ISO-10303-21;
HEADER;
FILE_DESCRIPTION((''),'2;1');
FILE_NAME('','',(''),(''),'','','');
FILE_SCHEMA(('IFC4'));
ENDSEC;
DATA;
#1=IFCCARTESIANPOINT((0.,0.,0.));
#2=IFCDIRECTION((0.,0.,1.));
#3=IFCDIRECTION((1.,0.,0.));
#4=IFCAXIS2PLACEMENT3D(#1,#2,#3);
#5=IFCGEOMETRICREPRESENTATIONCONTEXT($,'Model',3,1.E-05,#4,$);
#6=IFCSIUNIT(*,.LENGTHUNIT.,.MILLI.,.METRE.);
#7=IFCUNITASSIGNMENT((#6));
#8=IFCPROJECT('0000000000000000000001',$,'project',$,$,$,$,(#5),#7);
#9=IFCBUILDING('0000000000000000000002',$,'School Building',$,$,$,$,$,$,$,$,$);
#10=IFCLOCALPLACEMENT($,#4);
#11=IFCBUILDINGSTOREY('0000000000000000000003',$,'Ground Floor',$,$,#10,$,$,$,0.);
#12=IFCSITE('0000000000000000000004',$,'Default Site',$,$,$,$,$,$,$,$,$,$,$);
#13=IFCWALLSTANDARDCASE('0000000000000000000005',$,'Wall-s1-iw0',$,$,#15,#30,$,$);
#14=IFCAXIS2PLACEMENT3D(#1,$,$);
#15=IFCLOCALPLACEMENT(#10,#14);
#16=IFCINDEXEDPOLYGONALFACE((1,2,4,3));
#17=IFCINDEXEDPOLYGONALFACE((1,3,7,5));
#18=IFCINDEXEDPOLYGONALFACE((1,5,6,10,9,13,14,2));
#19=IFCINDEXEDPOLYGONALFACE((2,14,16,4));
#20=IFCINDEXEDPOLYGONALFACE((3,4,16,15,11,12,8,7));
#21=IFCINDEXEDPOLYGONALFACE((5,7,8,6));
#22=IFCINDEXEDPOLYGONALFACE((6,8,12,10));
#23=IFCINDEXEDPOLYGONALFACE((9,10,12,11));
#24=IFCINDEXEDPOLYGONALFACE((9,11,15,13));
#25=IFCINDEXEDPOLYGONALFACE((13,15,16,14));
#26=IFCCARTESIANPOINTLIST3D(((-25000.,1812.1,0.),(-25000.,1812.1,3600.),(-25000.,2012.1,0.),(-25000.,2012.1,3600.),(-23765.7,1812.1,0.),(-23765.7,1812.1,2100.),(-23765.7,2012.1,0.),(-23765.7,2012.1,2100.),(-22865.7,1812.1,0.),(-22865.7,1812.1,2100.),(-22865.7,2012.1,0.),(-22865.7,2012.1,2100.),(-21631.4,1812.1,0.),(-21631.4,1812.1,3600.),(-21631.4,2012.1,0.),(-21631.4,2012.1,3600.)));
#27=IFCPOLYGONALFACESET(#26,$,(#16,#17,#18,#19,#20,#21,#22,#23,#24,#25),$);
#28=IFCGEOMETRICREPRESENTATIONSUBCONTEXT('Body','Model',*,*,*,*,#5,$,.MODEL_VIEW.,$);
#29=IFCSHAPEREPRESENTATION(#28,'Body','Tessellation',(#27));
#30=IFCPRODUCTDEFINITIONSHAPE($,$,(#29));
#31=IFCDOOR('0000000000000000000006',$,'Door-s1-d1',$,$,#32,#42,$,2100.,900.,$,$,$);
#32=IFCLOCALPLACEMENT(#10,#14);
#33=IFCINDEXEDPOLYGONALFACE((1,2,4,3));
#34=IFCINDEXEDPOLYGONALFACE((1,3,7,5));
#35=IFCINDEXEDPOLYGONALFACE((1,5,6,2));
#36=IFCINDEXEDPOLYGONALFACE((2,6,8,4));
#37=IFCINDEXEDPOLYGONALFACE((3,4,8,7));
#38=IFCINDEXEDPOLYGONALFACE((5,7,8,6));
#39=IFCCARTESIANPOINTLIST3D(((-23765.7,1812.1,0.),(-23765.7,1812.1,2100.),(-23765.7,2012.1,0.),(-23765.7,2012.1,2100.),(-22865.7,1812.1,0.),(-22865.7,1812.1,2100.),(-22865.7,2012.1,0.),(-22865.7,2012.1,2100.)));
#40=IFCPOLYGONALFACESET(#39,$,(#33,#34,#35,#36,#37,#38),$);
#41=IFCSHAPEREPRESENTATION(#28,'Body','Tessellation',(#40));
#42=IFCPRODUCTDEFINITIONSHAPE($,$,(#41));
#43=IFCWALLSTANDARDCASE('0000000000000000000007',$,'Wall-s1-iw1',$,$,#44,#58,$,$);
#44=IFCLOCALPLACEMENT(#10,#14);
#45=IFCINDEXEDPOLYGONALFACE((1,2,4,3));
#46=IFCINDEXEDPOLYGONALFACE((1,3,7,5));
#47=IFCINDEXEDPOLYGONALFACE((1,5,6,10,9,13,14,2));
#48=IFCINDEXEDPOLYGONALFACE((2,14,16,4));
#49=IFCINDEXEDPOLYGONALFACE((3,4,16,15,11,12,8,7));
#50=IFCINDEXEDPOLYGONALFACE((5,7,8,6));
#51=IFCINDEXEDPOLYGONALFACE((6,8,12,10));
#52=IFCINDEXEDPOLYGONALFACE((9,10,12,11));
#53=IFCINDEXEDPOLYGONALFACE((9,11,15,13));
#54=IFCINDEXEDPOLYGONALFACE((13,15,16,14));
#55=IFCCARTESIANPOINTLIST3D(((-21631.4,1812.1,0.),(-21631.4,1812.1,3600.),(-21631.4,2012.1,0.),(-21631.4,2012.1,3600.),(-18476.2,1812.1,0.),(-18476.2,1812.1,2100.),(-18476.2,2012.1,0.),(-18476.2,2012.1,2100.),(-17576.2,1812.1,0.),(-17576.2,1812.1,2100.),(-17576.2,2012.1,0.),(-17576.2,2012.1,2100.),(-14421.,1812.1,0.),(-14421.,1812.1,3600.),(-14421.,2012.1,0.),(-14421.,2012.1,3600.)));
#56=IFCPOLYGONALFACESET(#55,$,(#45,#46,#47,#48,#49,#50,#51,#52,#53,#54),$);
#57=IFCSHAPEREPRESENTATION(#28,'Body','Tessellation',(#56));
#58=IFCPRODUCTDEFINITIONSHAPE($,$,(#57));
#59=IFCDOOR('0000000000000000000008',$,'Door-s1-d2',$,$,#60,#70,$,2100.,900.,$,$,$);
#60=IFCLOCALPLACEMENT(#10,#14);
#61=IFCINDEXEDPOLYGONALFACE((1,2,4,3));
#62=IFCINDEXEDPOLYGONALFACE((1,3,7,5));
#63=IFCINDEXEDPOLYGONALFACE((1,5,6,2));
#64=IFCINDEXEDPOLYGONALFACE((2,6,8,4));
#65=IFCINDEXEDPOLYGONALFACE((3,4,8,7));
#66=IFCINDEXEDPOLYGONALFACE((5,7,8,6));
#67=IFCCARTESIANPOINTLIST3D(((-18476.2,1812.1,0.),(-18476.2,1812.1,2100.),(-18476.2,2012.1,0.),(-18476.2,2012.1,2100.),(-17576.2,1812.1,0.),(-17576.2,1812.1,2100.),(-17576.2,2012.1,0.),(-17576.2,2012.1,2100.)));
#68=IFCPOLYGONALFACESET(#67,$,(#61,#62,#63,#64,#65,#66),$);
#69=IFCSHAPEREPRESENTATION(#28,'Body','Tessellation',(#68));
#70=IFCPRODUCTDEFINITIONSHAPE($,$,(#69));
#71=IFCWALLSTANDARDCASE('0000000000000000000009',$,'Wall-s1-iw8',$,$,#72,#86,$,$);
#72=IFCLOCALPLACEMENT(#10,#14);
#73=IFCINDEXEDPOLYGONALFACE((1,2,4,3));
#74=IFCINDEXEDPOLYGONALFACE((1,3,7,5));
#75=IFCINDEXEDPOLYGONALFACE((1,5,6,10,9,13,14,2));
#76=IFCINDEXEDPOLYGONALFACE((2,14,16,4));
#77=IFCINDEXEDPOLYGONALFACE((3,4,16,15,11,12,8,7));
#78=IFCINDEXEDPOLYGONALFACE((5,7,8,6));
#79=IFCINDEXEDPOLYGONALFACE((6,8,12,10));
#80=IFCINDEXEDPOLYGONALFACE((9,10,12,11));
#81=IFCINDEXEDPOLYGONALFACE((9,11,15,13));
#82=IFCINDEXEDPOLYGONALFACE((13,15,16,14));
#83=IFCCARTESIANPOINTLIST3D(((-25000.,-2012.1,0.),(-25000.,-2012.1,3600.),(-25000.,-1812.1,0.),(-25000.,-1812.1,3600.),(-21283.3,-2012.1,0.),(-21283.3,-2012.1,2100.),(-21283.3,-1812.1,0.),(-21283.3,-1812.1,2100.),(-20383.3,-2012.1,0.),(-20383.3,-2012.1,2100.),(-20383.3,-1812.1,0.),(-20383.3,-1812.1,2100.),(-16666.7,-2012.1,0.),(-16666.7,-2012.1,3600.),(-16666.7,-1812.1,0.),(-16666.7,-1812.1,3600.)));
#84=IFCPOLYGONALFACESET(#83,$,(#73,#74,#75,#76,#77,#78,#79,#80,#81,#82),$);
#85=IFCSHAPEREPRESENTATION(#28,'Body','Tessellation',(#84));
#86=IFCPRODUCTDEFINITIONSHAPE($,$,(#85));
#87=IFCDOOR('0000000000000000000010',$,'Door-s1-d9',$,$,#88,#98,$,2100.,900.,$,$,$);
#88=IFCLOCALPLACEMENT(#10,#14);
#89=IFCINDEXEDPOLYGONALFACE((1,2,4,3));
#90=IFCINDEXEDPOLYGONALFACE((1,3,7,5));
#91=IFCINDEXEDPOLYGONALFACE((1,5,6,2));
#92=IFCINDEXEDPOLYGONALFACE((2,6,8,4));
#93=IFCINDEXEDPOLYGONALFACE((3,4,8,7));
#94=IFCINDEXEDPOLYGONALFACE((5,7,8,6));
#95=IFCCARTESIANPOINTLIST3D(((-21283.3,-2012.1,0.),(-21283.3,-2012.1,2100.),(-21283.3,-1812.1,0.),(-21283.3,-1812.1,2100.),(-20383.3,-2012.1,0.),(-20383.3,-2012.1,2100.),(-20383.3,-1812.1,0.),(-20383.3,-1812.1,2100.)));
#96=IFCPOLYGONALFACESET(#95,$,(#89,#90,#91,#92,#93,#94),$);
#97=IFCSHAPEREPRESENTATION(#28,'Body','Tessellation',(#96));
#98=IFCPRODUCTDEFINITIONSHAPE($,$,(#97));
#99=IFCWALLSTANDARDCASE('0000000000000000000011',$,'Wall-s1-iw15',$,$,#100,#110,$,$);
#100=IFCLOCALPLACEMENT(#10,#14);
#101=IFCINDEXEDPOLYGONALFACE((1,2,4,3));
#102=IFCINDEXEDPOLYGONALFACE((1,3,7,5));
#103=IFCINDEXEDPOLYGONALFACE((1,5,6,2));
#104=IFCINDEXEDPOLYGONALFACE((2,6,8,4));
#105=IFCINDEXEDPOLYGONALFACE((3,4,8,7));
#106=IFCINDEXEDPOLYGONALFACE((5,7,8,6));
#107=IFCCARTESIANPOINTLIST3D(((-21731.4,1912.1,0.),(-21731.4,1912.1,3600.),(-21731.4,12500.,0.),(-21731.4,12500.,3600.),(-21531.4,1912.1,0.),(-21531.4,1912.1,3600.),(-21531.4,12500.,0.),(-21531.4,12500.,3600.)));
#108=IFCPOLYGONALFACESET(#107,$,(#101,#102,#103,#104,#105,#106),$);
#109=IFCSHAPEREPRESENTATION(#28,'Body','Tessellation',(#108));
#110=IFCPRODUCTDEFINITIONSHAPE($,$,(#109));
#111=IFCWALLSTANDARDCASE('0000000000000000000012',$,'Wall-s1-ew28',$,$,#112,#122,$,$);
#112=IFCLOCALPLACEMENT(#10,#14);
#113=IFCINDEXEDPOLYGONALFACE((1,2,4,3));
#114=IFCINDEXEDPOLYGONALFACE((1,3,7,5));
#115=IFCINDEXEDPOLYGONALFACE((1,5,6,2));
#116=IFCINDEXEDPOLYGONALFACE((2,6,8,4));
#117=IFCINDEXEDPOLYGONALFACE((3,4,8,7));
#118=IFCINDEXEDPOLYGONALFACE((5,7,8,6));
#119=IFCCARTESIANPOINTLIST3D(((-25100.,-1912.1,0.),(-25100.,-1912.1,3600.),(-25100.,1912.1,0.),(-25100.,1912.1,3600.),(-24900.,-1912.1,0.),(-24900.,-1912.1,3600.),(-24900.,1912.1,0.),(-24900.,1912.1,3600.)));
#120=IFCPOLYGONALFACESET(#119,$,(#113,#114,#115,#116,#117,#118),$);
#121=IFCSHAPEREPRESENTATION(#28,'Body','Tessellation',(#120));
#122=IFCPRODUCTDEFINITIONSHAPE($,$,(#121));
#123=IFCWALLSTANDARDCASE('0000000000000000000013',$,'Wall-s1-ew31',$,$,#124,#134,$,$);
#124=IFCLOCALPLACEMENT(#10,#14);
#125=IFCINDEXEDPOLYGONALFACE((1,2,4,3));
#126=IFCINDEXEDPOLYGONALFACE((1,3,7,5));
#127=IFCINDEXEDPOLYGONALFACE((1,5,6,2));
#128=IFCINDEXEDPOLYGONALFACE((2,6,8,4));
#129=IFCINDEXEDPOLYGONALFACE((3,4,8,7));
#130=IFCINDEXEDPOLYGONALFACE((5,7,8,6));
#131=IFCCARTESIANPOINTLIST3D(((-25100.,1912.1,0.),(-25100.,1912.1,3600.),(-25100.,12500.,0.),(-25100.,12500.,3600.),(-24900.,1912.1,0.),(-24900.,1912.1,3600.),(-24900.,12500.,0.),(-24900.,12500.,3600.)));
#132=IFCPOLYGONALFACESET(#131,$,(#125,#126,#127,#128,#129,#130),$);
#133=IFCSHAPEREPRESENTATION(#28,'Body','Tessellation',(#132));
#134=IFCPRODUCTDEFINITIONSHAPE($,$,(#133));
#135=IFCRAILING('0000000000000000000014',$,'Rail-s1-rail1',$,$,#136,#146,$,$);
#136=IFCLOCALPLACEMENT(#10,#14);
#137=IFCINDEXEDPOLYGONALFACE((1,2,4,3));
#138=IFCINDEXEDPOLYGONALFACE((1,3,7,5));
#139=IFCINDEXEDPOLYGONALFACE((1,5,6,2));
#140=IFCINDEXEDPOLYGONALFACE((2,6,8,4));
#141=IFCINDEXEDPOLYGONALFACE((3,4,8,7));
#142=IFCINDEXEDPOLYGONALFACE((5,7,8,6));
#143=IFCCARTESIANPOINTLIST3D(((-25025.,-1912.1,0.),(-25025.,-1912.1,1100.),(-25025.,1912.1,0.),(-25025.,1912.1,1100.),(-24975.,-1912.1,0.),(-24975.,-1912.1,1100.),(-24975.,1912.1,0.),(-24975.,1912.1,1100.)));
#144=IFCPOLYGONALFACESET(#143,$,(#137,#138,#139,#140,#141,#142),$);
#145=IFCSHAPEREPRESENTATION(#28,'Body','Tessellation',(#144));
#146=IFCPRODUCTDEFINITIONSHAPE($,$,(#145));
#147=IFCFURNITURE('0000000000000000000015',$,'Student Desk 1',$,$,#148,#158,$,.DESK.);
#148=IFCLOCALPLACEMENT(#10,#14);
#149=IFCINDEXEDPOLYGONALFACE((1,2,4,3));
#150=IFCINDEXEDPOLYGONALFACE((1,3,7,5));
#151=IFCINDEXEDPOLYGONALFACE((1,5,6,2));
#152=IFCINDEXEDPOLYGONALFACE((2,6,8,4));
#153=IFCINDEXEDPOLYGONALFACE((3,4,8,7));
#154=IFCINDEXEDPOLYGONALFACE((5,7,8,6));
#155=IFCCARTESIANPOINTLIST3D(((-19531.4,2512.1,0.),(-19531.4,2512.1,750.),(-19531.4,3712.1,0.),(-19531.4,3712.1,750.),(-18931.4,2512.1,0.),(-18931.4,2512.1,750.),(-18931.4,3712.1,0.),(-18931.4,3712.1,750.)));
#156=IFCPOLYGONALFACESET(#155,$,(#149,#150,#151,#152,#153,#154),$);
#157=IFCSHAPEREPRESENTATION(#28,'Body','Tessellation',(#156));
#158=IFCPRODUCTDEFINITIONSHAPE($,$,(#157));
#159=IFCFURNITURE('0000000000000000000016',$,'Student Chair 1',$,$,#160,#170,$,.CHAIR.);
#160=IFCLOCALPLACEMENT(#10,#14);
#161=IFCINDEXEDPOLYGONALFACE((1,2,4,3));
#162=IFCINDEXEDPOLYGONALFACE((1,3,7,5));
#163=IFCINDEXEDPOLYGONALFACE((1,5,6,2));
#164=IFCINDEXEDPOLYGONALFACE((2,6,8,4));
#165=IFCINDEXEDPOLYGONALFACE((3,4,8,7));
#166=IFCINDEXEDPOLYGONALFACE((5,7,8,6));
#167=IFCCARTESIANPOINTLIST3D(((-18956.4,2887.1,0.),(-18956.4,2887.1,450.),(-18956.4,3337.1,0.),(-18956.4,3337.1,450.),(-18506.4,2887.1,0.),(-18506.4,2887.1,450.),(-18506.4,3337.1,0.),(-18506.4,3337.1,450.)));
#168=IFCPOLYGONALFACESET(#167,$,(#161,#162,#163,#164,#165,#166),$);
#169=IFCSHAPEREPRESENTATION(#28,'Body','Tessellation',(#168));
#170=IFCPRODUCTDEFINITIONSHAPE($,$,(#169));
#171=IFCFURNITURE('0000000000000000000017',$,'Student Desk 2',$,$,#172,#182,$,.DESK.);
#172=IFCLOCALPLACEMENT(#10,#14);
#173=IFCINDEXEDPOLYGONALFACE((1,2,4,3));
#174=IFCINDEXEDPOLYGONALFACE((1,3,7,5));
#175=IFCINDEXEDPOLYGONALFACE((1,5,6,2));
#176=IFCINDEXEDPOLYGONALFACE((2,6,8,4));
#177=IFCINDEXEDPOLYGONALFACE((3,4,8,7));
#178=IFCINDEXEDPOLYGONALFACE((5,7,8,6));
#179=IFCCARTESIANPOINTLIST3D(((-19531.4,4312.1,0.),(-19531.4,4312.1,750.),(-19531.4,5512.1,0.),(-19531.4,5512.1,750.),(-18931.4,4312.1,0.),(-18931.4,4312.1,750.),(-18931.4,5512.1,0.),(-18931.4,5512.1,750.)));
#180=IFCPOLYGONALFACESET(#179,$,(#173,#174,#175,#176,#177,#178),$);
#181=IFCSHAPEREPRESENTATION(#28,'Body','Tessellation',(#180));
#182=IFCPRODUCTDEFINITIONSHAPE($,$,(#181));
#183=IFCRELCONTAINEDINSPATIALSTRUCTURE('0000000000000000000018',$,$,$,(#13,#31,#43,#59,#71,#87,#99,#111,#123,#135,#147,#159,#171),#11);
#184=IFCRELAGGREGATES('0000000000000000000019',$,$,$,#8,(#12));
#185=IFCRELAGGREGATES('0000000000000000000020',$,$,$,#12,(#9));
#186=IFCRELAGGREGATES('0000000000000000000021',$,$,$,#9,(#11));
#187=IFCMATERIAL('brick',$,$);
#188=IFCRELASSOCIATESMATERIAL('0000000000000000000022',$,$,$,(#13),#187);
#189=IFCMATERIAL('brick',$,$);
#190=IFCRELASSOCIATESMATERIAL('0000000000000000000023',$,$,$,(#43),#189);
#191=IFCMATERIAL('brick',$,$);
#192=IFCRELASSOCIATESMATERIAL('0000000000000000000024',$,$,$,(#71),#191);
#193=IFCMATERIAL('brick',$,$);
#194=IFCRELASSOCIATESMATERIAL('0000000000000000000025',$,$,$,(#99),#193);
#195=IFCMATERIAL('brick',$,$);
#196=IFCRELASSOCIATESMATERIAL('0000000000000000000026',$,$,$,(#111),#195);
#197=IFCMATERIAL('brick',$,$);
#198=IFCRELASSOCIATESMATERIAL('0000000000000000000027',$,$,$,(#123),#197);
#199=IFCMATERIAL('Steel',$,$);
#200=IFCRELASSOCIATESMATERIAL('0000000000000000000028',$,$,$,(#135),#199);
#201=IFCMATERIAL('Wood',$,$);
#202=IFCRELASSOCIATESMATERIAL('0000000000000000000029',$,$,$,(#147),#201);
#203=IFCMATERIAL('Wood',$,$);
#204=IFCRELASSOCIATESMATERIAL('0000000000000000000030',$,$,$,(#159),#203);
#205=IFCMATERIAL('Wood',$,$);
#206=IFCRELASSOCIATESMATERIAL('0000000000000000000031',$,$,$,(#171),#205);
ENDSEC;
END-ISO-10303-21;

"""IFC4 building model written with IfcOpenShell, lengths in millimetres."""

from ifc_helpers import new_model, si_unit, frame, frame_2d, origin_with_axes, origin_2d, place, context, subcontext, project, spatial, rectangle, extrude, material, element, fill, save


model = new_model("IFC4")

# Units and contexts
model_context = context("Model", 3, precision=1e-05, world=origin_with_axes())
body_context = subcontext(model_context, "Body", "Model", "MODEL_VIEW")
ifc_project = project(units=[si_unit("LENGTHUNIT", "METRE", prefix="MILLI")], contexts=[model_context])

# Site, building, storey
site = spatial("IfcSite", under=ifc_project, Name="Default Site")
building = spatial("IfcBuilding", under=site, Name="School Building")
storey_placement = place(None, origin_with_axes())
storey = spatial("IfcBuildingStorey", under=building, at=storey_placement, Name="Ground Floor", Elevation=0.0)

# Walls, openings, doors
ifc_material_1 = material(Name="brick")
wall_1_placement = place(storey_placement, frame((-25000.0, 1912.1, 0.0), z_axis=(0.0, 0.0, 1.0), x_axis=(1.0, 0.0, 0.0)))
wall_1 = element("IfcWallStandardCase", 1, at=wall_1_placement, inside=storey, material=ifc_material_1, Name="Wall-s1-iw0", context=body_context, shape_type="SweptSolid", body=[
    extrude(rectangle(XDim=3368.6, YDim=200.0, at=frame_2d((1684.3, 0.0))), origin_with_axes(), (0.0, 0.0, 1.0), 3600.0),
])
opening_1_placement = place(wall_1_placement, frame((1234.3, 0.0, 0.0), z_axis=(0.0, 0.0, 1.0), x_axis=(1.0, 0.0, 0.0)))
opening_1 = element("IfcOpeningElement", 2, at=opening_1_placement, cuts=wall_1, context=body_context, shape_type="SweptSolid", body=[
    extrude(rectangle(XDim=900.0, YDim=400.0, at=frame_2d((450.0, 0.0))), origin_with_axes(), (0.0, 0.0, 1.0), 2100.0),
])
door_1_placement = place(storey_placement, frame((-23765.7, 1912.1, 0.0), z_axis=(0.0, 0.0, 1.0), x_axis=(1.0, 0.0, 0.0)))
door_1 = element("IfcDoor", 3, at=door_1_placement, inside=storey, Name="Door-s1-d1", OverallHeight=2100.0, OverallWidth=900.0, context=body_context, shape_type="SweptSolid", body=[
    extrude(rectangle(XDim=900.0, YDim=200.0, at=frame_2d((450.0, 0.0))), origin_with_axes(), (0.0, 0.0, 1.0), 2100.0),
])
fill(opening_1, door_1)
ifc_material_2 = material(Name="brick")
wall_2_placement = place(storey_placement, frame((-21631.4, 1912.1, 0.0), z_axis=(0.0, 0.0, 1.0), x_axis=(1.0, 0.0, 0.0)))
wall_2 = element("IfcWallStandardCase", 4, at=wall_2_placement, inside=storey, material=ifc_material_2, Name="Wall-s1-iw1", context=body_context, shape_type="SweptSolid", body=[
    extrude(rectangle(XDim=7210.5, YDim=200.0, at=frame_2d((3605.2, 0.0))), origin_with_axes(), (0.0, 0.0, 1.0), 3600.0),
])
opening_2_placement = place(wall_2_placement, frame((3155.2, 0.0, 0.0), z_axis=(0.0, 0.0, 1.0), x_axis=(1.0, 0.0, 0.0)))
opening_2 = element("IfcOpeningElement", 5, at=opening_2_placement, cuts=wall_2, context=body_context, shape_type="SweptSolid", body=[
    extrude(rectangle(XDim=900.0, YDim=400.0, at=frame_2d((450.0, 0.0))), origin_with_axes(), (0.0, 0.0, 1.0), 2100.0),
])
door_2_placement = place(storey_placement, frame((-18476.2, 1912.1, 0.0), z_axis=(0.0, 0.0, 1.0), x_axis=(1.0, 0.0, 0.0)))
door_2 = element("IfcDoor", 6, at=door_2_placement, inside=storey, Name="Door-s1-d2", OverallHeight=2100.0, OverallWidth=900.0, context=body_context, shape_type="SweptSolid", body=[
    extrude(rectangle(XDim=900.0, YDim=200.0, at=frame_2d((450.0, 0.0))), origin_with_axes(), (0.0, 0.0, 1.0), 2100.0),
])
fill(opening_2, door_2)
ifc_material_3 = material(Name="brick")
wall_3_placement = place(storey_placement, frame((-25000.0, -1912.1, 0.0), z_axis=(0.0, 0.0, 1.0), x_axis=(1.0, 0.0, 0.0)))
wall_3 = element("IfcWallStandardCase", 7, at=wall_3_placement, inside=storey, material=ifc_material_3, Name="Wall-s1-iw8", context=body_context, shape_type="SweptSolid", body=[
    extrude(rectangle(XDim=8333.3, YDim=200.0, at=frame_2d((4166.7, 0.0))), origin_with_axes(), (0.0, 0.0, 1.0), 3600.0),
])
opening_3_placement = place(wall_3_placement, frame((3716.7, 0.0, 0.0), z_axis=(0.0, 0.0, 1.0), x_axis=(1.0, 0.0, 0.0)))
opening_3 = element("IfcOpeningElement", 8, at=opening_3_placement, cuts=wall_3, context=body_context, shape_type="SweptSolid", body=[
    extrude(rectangle(XDim=900.0, YDim=400.0, at=frame_2d((450.0, 0.0))), origin_with_axes(), (0.0, 0.0, 1.0), 2100.0),
])
door_3_placement = place(storey_placement, frame((-21283.3, -1912.1, 0.0), z_axis=(0.0, 0.0, 1.0), x_axis=(1.0, 0.0, 0.0)))
door_3 = element("IfcDoor", 9, at=door_3_placement, inside=storey, Name="Door-s1-d9", OverallHeight=2100.0, OverallWidth=900.0, context=body_context, shape_type="SweptSolid", body=[
    extrude(rectangle(XDim=900.0, YDim=200.0, at=frame_2d((450.0, 0.0))), origin_with_axes(), (0.0, 0.0, 1.0), 2100.0),
])
fill(opening_3, door_3)

# Walls
ifc_material_4 = material(Name="brick")
wall_4_placement = place(storey_placement, frame((-21631.4, 1912.1, 0.0), z_axis=(0.0, 0.0, 1.0), x_axis=(0.0, 1.0, 0.0)))
element("IfcWallStandardCase", 10, at=wall_4_placement, inside=storey, material=ifc_material_4, Name="Wall-s1-iw15", context=body_context, shape_type="SweptSolid", body=[
    extrude(rectangle(XDim=10587.9, YDim=200.0, at=frame_2d((5293.9, 0.0))), origin_with_axes(), (0.0, 0.0, 1.0), 3600.0),
])
ifc_material_5 = material(Name="brick")
wall_5_placement = place(storey_placement, frame((-25000.0, -1912.1, 0.0), z_axis=(0.0, 0.0, 1.0), x_axis=(0.0, 1.0, 0.0)))
element("IfcWallStandardCase", 11, at=wall_5_placement, inside=storey, material=ifc_material_5, Name="Wall-s1-ew28", context=body_context, shape_type="SweptSolid", body=[
    extrude(rectangle(XDim=3824.2, YDim=200.0, at=frame_2d((1912.1, 0.0))), origin_with_axes(), (0.0, 0.0, 1.0), 3600.0),
])
ifc_material_6 = material(Name="brick")
wall_6_placement = place(storey_placement, frame((-25000.0, 1912.1, 0.0), z_axis=(0.0, 0.0, 1.0), x_axis=(0.0, 1.0, 0.0)))
element("IfcWallStandardCase", 12, at=wall_6_placement, inside=storey, material=ifc_material_6, Name="Wall-s1-ew31", context=body_context, shape_type="SweptSolid", body=[
    extrude(rectangle(XDim=10587.9, YDim=200.0, at=frame_2d((5293.9, 0.0))), origin_with_axes(), (0.0, 0.0, 1.0), 3600.0),
])

# Railing
ifc_material_7 = material(Name="Steel")
railing_placement = place(storey_placement, frame((-25000.0, -1912.1, 0.0), z_axis=(0.0, 0.0, 1.0), x_axis=(0.0, 1.0, 0.0)))
element("IfcRailing", 13, at=railing_placement, inside=storey, material=ifc_material_7, Name="Rail-s1-rail1", context=body_context, shape_type="SweptSolid", body=[
    extrude(rectangle(XDim=3824.2, YDim=50.0, at=frame_2d((1912.1, 0.0))), origin_with_axes(), (0.0, 0.0, 1.0), 1100.0),
])

# Furniture
ifc_material_8 = material(Name="Wood")
furniture_1_placement = place(storey_placement, frame((-19231.4, 3112.1, 0.0), z_axis=(0.0, 0.0, 1.0), x_axis=(0.0, 1.0, 0.0)))
element("IfcFurniture", 14, at=furniture_1_placement, inside=storey, material=ifc_material_8, Name="Student Desk 1", PredefinedType="DESK", context=body_context, shape_type="SweptSolid", body=[
    extrude(rectangle(XDim=1200.0, YDim=600.0, at=origin_2d()), origin_with_axes(), (0.0, 0.0, 1.0), 750.0),
])
ifc_material_9 = material(Name="Wood")
furniture_2_placement = place(storey_placement, frame((-18731.4, 3112.1, 0.0), z_axis=(0.0, 0.0, 1.0), x_axis=(1.0, 0.0, 0.0)))
element("IfcFurniture", 15, at=furniture_2_placement, inside=storey, material=ifc_material_9, Name="Student Chair 1", PredefinedType="CHAIR", context=body_context, shape_type="SweptSolid", body=[
    extrude(rectangle(XDim=450.0, YDim=450.0, at=origin_2d()), origin_with_axes(), (0.0, 0.0, 1.0), 450.0),
])
ifc_material_10 = material(Name="Wood")
furniture_3_placement = place(storey_placement, frame((-19231.4, 4912.1, 0.0), z_axis=(0.0, 0.0, 1.0), x_axis=(0.0, 1.0, 0.0)))
element("IfcFurniture", 16, at=furniture_3_placement, inside=storey, material=ifc_material_10, Name="Student Desk 2", PredefinedType="DESK", context=body_context, shape_type="SweptSolid", body=[
    extrude(rectangle(XDim=1200.0, YDim=600.0, at=origin_2d()), origin_with_axes(), (0.0, 0.0, 1.0), 750.0),
])

save(model, "model.ifc")
